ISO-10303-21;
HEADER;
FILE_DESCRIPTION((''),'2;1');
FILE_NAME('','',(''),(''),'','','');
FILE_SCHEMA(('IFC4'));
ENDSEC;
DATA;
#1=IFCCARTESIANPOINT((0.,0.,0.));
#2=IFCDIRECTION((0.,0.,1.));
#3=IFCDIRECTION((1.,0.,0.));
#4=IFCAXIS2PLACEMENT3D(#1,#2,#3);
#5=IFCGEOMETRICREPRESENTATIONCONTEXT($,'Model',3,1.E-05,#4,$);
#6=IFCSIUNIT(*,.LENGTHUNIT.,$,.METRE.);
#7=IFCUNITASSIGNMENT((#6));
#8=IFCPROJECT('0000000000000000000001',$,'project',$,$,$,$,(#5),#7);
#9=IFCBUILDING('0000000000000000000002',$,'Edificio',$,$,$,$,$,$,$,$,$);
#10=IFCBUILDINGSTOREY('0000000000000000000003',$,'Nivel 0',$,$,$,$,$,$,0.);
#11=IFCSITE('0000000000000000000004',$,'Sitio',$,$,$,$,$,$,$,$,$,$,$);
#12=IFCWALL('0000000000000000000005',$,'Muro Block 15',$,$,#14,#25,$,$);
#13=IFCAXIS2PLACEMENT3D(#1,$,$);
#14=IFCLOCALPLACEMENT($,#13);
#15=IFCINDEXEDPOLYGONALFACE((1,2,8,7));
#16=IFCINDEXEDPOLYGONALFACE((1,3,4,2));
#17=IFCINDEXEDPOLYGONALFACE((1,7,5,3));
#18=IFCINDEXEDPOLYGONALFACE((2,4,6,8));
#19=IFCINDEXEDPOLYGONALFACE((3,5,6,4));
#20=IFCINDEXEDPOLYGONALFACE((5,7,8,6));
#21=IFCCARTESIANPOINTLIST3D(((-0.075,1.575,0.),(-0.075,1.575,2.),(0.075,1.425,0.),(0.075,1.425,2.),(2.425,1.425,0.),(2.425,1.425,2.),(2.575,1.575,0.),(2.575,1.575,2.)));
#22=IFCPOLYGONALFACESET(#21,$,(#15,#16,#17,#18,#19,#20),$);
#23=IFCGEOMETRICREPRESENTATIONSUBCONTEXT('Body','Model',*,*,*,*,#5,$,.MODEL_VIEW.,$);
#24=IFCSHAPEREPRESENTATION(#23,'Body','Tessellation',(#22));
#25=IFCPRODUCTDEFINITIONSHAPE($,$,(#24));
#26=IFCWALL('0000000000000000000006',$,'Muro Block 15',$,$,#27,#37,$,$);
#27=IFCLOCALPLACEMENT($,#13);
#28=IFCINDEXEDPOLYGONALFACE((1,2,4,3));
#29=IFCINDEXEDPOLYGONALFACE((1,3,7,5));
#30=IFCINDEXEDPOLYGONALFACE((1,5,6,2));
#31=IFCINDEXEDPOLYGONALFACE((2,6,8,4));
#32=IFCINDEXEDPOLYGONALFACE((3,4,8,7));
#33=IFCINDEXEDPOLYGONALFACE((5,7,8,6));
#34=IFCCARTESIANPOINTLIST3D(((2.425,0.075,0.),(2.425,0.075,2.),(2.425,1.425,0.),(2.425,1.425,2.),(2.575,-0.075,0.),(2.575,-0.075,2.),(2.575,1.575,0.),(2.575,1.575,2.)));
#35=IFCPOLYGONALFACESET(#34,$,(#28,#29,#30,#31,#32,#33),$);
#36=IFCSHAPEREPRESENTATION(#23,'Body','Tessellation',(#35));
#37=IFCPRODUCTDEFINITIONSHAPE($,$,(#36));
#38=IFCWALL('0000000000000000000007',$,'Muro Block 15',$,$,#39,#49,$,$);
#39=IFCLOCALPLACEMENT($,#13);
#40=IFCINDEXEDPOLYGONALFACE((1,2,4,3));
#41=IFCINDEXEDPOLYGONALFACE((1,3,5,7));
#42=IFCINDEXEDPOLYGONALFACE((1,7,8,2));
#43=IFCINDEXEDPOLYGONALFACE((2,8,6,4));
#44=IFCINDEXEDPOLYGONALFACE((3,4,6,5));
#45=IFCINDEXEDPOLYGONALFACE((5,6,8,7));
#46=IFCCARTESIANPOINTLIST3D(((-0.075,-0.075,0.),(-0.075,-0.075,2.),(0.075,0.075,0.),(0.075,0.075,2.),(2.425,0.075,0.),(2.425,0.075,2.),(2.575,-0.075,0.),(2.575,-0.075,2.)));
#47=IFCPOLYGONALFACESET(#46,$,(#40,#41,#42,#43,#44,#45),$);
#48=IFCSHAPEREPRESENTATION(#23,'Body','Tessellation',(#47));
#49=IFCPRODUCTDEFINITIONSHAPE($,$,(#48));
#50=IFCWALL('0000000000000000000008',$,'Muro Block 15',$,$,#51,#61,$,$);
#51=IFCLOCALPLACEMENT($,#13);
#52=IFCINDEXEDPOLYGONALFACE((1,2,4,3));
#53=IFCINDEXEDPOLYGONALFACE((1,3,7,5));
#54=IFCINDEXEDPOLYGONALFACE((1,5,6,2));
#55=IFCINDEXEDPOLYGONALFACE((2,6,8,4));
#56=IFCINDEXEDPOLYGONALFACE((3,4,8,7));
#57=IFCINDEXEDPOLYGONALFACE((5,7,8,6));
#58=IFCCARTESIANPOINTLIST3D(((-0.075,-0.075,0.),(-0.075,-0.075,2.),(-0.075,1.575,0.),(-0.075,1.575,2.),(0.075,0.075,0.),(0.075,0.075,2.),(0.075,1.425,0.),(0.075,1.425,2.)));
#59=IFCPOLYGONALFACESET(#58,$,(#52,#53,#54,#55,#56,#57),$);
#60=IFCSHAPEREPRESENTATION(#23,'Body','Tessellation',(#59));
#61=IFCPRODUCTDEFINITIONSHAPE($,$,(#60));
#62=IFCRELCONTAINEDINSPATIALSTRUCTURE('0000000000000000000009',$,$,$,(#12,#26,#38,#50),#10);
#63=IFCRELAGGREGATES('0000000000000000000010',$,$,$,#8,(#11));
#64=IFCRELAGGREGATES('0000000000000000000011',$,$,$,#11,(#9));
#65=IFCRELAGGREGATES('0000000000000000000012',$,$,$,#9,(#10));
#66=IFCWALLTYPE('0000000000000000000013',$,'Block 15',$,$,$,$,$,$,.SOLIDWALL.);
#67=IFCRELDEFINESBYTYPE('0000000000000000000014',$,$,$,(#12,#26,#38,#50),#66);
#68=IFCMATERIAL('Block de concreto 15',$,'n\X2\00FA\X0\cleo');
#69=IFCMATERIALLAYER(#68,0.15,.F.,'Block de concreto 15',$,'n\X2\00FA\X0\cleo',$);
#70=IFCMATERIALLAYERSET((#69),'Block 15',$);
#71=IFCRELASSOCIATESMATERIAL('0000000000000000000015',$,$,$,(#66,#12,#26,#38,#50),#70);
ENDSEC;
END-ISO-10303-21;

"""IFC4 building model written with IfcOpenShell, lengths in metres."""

from ifc_helpers import new_model, si_unit, frame, origin_with_axes, place, context, subcontext, project, spatial, indexed_curve, outline, extrude, material, layer, layer_set, layer_usage, type_object, element, save


model = new_model("IFC4")

# Units and contexts
model_context = context("Model", 3, precision=1e-05, world=origin_with_axes())
body_context = subcontext(model_context, "Body", "Model", "MODEL_VIEW")
ifc_project = project(units=[si_unit("LENGTHUNIT", "METRE")], contexts=[model_context])

# Site, building, storey
site = spatial("IfcSite", under=ifc_project, Name="Sitio")
building = spatial("IfcBuilding", under=site, Name="Edificio")
storey = spatial("IfcBuildingStorey", under=building, Name="Nivel 0", Elevation=0.0)

# Walls
ifc_material = material(Name="Block de concreto 15", Category="núcleo")
ifc_layer = layer(ifc_material, 0.15, ventilated=False, Name="Block de concreto 15", Category="núcleo")
ifc_layer_set = layer_set([ifc_layer], Name="Block 15")
ifc_layer_usage_1 = layer_usage(ifc_layer_set, "AXIS2", "POSITIVE", 0.0)
wall_type = type_object("IfcWallType", Name="Block 15", PredefinedType="SOLIDWALL", material=ifc_layer_set)
wall_1_placement = place(None, frame((0.0, 1.5, 0.0), z_axis=(0.0, 0.0, 1.0), x_axis=(1.0, 0.0, 0.0)))
element("IfcWall", 1, at=wall_1_placement, inside=storey, type_object=wall_type, material=ifc_layer_usage_1, Name="Muro Block 15", context=body_context, shape_type="SweptSolid", body=[
    extrude(outline(indexed_curve([(0.075, -0.075), (2.425, -0.075), (2.575, 0.075), (-0.075, 0.075)])), None, (0.0, 0.0, 1.0), 2.0),
])
ifc_layer_usage_2 = layer_usage(ifc_layer_set, "AXIS2", "POSITIVE", 0.0)
wall_2_placement = place(None, frame((2.5, 1.5, 0.0), z_axis=(0.0, 0.0, 1.0), x_axis=(0.0, -1.0, 0.0)))
element("IfcWall", 2, at=wall_2_placement, inside=storey, type_object=wall_type, material=ifc_layer_usage_2, Name="Muro Block 15", context=body_context, shape_type="SweptSolid", body=[
    extrude(outline(indexed_curve([(0.075, -0.075), (1.425, -0.075), (1.575, 0.075), (-0.075, 0.075)])), None, (0.0, 0.0, 1.0), 2.0),
])
ifc_layer_usage_3 = layer_usage(ifc_layer_set, "AXIS2", "POSITIVE", 0.0)
wall_3_placement = place(None, frame((2.5, 0.0, 0.0), z_axis=(0.0, 0.0, 1.0), x_axis=(-1.0, 0.0, 0.0)))
element("IfcWall", 3, at=wall_3_placement, inside=storey, type_object=wall_type, material=ifc_layer_usage_3, Name="Muro Block 15", context=body_context, shape_type="SweptSolid", body=[
    extrude(outline(indexed_curve([(0.075, -0.075), (2.425, -0.075), (2.575, 0.075), (-0.075, 0.075)])), None, (0.0, 0.0, 1.0), 2.0),
])
ifc_layer_usage_4 = layer_usage(ifc_layer_set, "AXIS2", "POSITIVE", 0.0)
wall_4_placement = place(None, frame((0.0, 0.0, 0.0), z_axis=(0.0, 0.0, 1.0), x_axis=(0.0, 1.0, 0.0)))
element("IfcWall", 4, at=wall_4_placement, inside=storey, type_object=wall_type, material=ifc_layer_usage_4, Name="Muro Block 15", context=body_context, shape_type="SweptSolid", body=[
    extrude(outline(indexed_curve([(0.075, -0.075), (1.425, -0.075), (1.575, 0.075), (-0.075, 0.075)])), None, (0.0, 0.0, 1.0), 2.0),
])

save(model, "model.ifc")
